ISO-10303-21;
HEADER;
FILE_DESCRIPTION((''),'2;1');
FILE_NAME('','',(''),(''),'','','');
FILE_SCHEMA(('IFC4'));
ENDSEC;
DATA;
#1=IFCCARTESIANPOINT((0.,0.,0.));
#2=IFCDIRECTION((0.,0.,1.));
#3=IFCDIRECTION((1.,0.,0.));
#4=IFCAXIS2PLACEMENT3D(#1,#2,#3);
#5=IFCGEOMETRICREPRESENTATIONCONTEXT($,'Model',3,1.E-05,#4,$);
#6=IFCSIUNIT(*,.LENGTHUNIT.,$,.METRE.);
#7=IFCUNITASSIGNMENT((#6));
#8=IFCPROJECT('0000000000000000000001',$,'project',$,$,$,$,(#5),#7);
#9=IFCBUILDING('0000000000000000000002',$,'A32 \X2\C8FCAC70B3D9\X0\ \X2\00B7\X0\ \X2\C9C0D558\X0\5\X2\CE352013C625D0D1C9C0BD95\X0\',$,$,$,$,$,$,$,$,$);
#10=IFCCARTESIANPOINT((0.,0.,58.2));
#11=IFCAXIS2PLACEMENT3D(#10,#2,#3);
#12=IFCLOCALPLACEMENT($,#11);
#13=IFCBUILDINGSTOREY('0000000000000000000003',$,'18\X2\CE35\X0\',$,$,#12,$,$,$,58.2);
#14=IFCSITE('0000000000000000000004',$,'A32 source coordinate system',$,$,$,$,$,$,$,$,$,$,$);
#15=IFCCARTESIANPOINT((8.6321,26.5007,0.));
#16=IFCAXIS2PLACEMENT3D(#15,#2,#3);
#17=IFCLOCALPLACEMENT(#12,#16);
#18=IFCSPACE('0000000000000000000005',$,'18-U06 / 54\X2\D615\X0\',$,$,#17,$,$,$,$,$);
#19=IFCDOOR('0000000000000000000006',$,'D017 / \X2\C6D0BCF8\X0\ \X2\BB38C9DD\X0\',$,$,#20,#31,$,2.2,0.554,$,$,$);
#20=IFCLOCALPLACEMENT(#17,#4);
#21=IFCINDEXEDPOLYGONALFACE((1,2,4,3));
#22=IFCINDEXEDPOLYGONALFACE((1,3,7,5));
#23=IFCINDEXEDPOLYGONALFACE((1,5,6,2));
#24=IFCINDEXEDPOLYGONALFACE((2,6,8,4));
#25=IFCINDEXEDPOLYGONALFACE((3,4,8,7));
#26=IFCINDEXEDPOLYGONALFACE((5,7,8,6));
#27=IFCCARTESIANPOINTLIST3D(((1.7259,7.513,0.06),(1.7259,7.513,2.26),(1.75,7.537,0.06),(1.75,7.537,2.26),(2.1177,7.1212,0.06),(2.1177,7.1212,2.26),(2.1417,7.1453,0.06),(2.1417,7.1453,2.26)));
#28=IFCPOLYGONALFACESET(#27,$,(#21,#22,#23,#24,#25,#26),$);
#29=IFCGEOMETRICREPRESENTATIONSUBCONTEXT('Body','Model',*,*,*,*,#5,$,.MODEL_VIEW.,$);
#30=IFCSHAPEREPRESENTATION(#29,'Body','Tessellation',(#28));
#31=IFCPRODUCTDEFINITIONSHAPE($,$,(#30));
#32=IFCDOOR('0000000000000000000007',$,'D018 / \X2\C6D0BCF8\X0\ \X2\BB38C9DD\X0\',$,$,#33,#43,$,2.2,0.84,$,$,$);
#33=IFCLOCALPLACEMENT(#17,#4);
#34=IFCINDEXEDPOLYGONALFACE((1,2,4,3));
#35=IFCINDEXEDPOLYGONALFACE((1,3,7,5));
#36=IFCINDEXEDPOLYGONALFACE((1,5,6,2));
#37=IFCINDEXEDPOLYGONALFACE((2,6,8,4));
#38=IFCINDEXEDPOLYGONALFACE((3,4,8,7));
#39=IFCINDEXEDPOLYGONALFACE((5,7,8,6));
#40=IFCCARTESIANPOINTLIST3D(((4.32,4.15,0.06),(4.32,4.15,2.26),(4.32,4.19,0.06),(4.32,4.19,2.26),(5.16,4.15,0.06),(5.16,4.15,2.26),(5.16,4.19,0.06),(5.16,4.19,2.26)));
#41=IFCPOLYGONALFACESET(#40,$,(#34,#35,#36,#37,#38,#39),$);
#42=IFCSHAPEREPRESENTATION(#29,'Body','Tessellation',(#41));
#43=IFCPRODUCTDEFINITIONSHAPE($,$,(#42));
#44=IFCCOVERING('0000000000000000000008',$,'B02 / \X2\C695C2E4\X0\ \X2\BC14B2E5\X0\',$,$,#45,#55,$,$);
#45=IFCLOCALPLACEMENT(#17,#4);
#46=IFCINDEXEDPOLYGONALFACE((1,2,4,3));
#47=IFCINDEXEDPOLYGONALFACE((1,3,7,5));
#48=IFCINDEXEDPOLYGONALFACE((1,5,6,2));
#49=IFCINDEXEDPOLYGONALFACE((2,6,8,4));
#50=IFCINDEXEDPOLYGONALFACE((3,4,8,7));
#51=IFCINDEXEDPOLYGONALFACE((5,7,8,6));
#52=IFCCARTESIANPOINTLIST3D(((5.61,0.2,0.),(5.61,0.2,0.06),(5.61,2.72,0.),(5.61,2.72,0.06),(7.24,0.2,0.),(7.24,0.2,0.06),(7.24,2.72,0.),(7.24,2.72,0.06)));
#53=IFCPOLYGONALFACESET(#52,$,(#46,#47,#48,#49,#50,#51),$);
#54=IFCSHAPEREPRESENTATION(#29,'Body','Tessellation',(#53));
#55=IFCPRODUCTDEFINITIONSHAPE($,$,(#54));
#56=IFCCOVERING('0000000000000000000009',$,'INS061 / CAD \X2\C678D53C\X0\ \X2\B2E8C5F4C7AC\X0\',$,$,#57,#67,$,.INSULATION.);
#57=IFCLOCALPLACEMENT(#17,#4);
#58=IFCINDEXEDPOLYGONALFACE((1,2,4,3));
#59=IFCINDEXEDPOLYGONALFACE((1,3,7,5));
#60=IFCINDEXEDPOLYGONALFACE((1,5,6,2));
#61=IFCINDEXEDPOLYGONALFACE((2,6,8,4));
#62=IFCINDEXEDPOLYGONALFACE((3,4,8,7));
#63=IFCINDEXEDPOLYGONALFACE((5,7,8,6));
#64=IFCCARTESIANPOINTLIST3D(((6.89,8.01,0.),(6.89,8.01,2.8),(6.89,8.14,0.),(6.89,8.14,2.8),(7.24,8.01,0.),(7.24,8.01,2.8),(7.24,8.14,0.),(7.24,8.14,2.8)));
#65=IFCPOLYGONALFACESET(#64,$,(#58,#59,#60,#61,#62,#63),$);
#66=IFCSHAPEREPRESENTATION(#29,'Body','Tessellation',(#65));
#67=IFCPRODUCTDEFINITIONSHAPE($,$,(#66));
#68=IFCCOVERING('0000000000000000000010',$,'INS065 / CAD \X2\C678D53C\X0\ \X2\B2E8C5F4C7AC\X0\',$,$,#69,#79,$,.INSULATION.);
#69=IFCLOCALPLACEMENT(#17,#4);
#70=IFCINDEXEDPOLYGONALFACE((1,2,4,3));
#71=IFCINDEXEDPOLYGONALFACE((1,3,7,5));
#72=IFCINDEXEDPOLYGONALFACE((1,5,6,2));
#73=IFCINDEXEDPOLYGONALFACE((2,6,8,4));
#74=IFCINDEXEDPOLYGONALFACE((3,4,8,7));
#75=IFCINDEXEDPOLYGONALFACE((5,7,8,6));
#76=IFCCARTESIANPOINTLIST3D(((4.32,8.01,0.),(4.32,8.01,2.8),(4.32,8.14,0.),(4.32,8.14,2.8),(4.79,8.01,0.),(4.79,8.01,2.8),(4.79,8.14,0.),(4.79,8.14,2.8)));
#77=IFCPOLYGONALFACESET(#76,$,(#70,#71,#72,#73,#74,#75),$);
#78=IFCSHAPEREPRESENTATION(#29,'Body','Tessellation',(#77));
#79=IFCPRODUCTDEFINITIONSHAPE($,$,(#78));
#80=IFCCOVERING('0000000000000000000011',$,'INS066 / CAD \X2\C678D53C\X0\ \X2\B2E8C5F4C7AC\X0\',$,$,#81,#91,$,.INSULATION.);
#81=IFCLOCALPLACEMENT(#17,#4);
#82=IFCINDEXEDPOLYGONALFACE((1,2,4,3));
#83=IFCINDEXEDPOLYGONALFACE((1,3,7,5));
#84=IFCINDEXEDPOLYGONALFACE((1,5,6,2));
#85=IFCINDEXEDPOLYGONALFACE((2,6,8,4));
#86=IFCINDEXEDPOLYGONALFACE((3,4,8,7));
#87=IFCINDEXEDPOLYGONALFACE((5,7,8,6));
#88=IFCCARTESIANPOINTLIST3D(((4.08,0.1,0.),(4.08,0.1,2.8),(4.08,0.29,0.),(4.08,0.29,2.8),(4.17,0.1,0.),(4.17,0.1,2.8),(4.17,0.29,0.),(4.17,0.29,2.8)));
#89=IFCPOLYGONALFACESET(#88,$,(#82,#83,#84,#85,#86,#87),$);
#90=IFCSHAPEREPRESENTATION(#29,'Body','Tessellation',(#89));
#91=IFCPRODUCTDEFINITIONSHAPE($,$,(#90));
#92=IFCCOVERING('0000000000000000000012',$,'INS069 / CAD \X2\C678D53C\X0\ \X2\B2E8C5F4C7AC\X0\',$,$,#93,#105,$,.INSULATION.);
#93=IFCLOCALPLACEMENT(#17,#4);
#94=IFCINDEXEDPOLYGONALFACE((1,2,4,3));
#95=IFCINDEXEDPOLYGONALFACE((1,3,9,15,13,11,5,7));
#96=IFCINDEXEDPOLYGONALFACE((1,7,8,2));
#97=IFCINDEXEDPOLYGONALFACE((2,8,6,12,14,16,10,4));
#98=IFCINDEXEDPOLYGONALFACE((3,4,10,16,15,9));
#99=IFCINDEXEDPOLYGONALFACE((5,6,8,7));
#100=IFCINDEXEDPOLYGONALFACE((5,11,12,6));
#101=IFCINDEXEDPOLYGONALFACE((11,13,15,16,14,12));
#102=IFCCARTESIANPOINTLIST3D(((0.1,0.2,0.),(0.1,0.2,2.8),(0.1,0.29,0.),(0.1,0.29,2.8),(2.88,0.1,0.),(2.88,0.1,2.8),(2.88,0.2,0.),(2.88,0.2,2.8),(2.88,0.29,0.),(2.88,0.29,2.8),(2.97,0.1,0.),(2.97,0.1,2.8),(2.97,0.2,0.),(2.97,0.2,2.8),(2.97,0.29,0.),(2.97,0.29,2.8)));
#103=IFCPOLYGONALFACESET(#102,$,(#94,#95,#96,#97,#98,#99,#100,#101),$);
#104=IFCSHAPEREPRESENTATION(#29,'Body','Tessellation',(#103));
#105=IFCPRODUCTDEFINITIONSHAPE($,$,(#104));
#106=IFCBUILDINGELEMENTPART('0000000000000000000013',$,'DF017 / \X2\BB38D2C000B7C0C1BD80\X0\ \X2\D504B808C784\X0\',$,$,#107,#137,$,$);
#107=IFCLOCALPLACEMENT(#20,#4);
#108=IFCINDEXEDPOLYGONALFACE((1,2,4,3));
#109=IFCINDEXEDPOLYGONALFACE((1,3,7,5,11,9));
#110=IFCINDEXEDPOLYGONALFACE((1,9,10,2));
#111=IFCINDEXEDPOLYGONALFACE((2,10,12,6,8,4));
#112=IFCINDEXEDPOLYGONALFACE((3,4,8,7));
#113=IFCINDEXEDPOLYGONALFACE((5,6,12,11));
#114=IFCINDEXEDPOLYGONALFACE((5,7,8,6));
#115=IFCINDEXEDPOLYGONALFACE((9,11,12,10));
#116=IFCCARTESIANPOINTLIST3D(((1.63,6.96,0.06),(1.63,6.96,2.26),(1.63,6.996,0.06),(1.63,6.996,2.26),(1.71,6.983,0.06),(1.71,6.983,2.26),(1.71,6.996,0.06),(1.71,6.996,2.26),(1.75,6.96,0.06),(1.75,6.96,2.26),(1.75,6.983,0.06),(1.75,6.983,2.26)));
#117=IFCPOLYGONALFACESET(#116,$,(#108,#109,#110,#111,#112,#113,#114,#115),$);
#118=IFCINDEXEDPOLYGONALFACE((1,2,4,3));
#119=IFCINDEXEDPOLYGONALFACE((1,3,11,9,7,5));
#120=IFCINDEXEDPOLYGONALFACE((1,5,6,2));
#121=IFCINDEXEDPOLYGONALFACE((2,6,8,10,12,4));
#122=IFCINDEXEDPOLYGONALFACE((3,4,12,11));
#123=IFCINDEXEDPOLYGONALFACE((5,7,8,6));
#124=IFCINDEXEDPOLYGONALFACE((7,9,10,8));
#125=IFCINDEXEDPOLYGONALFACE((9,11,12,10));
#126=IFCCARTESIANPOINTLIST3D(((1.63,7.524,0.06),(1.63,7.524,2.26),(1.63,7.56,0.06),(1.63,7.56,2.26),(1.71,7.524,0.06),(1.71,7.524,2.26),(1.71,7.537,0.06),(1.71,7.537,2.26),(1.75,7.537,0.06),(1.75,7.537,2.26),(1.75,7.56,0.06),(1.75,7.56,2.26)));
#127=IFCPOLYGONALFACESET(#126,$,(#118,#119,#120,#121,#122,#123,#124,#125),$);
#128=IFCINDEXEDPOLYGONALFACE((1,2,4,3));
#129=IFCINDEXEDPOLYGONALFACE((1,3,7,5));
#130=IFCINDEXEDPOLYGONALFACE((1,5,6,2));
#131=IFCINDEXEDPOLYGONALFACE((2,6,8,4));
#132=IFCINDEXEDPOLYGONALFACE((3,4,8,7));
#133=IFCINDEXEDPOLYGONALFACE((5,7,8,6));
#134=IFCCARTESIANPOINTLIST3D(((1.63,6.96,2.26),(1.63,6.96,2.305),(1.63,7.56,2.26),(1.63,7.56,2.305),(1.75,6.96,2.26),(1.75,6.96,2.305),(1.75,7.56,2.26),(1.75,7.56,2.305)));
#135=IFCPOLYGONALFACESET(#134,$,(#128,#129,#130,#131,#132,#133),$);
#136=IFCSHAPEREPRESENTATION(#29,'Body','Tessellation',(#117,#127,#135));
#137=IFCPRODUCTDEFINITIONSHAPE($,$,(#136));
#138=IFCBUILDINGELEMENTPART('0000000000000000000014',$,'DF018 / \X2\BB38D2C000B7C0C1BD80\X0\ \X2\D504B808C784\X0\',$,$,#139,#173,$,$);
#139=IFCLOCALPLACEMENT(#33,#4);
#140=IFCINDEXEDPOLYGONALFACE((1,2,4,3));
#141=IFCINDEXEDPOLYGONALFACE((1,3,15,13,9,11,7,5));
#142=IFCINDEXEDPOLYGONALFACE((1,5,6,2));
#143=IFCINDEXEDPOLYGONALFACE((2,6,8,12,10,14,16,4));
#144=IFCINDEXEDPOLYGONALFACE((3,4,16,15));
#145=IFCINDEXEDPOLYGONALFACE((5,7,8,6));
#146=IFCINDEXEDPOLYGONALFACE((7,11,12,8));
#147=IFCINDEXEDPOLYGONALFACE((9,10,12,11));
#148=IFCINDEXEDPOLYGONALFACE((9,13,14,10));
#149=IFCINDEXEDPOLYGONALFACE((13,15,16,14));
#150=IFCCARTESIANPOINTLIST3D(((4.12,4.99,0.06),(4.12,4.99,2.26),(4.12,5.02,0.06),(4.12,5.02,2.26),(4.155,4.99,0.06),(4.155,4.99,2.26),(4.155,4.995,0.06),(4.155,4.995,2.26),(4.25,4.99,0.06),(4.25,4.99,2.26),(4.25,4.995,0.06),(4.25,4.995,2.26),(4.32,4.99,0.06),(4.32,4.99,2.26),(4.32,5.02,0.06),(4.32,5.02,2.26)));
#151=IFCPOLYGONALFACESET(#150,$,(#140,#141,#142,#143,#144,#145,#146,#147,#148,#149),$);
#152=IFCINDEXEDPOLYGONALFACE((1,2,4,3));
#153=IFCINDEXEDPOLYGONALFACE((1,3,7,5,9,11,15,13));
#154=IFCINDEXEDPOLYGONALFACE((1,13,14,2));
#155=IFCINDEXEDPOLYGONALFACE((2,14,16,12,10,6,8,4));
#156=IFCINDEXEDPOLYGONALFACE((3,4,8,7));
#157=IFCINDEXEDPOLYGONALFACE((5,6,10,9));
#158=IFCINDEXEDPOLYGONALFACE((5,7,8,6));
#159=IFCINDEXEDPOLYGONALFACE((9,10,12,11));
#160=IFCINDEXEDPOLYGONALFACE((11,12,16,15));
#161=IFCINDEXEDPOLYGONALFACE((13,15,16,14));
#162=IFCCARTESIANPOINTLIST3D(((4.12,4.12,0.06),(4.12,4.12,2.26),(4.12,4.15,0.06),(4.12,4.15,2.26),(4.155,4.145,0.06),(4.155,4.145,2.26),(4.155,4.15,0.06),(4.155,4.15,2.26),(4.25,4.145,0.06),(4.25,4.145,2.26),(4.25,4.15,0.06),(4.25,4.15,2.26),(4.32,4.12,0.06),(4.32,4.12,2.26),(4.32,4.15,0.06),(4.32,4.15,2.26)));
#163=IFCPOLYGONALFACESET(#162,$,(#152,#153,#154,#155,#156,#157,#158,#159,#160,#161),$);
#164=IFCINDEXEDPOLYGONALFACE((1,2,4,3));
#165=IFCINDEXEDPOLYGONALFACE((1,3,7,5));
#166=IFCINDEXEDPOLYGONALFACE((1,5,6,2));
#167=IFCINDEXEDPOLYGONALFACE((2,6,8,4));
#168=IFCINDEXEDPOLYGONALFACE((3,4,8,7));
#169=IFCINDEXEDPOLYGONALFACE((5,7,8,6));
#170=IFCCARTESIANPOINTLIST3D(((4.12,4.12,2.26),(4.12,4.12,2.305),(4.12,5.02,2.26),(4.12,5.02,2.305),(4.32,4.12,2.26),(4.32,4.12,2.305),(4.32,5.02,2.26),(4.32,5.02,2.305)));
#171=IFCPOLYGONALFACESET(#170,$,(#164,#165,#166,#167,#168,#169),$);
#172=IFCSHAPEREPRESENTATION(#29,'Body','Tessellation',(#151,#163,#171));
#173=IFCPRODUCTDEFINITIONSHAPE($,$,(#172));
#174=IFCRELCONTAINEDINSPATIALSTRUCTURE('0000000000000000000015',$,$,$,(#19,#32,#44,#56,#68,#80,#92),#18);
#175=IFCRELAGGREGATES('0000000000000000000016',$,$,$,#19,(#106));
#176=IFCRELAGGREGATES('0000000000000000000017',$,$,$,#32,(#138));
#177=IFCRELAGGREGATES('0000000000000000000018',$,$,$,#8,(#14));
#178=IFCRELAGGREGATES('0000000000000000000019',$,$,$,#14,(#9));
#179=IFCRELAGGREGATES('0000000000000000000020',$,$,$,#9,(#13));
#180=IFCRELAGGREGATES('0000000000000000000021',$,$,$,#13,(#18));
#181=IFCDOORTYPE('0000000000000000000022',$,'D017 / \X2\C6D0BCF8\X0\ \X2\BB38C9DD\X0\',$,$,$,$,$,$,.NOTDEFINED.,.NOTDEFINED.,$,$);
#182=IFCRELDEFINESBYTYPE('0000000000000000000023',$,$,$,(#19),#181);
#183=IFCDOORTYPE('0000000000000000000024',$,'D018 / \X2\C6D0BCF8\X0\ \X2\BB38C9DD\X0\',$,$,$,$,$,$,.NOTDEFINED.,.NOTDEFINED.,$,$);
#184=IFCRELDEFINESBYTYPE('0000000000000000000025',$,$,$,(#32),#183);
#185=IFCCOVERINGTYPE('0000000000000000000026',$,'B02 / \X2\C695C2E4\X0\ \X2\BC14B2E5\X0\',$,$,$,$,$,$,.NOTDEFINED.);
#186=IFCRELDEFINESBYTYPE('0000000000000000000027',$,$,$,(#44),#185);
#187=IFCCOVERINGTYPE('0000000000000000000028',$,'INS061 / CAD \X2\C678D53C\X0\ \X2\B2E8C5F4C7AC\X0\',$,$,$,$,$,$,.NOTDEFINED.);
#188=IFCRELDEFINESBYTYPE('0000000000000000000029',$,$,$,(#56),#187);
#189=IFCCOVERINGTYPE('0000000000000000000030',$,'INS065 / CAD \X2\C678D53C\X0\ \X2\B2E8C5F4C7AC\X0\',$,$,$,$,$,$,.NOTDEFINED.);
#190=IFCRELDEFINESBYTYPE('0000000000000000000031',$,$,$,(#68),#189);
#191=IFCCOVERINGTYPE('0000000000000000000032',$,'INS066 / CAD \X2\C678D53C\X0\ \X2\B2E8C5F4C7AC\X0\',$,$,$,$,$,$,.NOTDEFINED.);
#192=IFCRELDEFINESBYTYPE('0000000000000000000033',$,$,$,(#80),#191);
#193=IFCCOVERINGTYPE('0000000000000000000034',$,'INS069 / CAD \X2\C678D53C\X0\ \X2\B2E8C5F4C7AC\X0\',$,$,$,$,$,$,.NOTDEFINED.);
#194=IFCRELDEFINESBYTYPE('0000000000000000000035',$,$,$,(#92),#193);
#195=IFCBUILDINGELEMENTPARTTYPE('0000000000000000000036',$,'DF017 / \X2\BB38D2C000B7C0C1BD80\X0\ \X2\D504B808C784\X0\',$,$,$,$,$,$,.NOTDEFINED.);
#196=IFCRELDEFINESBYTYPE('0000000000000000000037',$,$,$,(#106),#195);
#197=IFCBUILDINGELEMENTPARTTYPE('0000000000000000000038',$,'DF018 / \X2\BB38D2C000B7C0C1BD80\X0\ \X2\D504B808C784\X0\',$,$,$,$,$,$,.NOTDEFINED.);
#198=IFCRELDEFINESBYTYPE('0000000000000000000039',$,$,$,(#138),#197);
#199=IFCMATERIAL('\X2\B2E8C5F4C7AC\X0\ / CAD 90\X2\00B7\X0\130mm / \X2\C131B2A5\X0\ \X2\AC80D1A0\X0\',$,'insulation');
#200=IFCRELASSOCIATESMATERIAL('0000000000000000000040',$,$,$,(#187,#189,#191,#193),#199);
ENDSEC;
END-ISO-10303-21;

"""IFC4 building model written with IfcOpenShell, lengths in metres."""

from ifc_helpers import new_model, si_unit, frame, origin, origin_with_axes, place, context, subcontext, project, spatial, polyline, outline, extrude, source, transform, mapped, material, type_object, type_shapes, element, aggregate, save


model = new_model("IFC4")

# Units and contexts
model_context = context("Model", 3, precision=1e-05, world=origin_with_axes())
body_context = subcontext(model_context, "Body", "Model", "MODEL_VIEW")
ifc_project = project(units=[si_unit("LENGTHUNIT", "METRE")], contexts=[model_context])

# Site, building, storey, space
storey_placement = place(None, frame((0.0, 0.0, 58.2), z_axis=(0.0, 0.0, 1.0), x_axis=(1.0, 0.0, 0.0)))
space_1_placement = place(storey_placement, frame((8.6321, 26.5007, 0.0), z_axis=(0.0, 0.0, 1.0), x_axis=(1.0, 0.0, 0.0)))
site = spatial("IfcSite", under=ifc_project, Name="A32 source coordinate system")
building = spatial("IfcBuilding", under=site, Name="A32 주거동 · 지하5층–옥탑지붕")
storey = spatial("IfcBuildingStorey", under=building, at=storey_placement, Name="18층", Elevation=58.2)
space_1 = spatial("IfcSpace", under=storey, at=space_1_placement, Name="18-U06 / 54형")

# Doors
door_type_1 = type_object("IfcDoorType", Name="D017 / 원본 문짝", OperationType="NOTDEFINED", PredefinedType="NOTDEFINED")
shared_shape_1 = source(origin(), body_context, "Body", "SweptSolid", [
    extrude(outline(polyline([(1.75, 7.537), (2.1417, 7.1453), (2.1177, 7.1212), (1.7259, 7.513), (1.75, 7.537)])), frame((0.0, 0.0, 0.06)), (0.0, 0.0, 1.0), 2.2),
])
type_shapes(door_type_1, [shared_shape_1])
door_1_placement = place(space_1_placement, origin_with_axes())
door_1 = element("IfcDoor", 1, at=door_1_placement, inside=space_1, type_object=door_type_1, Name="D017 / 원본 문짝", OverallHeight=2.2, OverallWidth=0.554, context=body_context, shape_type="MappedRepresentation", body=[
    mapped(shared_shape_1, transform((0.0, 0.0, 0.0), scale=1.0)),
])
door_type_2 = type_object("IfcDoorType", Name="D018 / 원본 문짝", OperationType="NOTDEFINED", PredefinedType="NOTDEFINED")
shared_shape_2 = source(origin(), body_context, "Body", "SweptSolid", [
    extrude(outline(polyline([(5.16, 4.19), (5.16, 4.15), (4.32, 4.15), (4.32, 4.19), (5.16, 4.19)])), frame((0.0, 0.0, 0.06)), (0.0, 0.0, 1.0), 2.2),
])
type_shapes(door_type_2, [shared_shape_2])
door_2_placement = place(space_1_placement, origin_with_axes())
door_2 = element("IfcDoor", 2, at=door_2_placement, inside=space_1, type_object=door_type_2, Name="D018 / 원본 문짝", OverallHeight=2.2, OverallWidth=0.84, context=body_context, shape_type="MappedRepresentation", body=[
    mapped(shared_shape_2, transform((0.0, 0.0, 0.0), scale=1.0)),
])

# Coverings
covering_type_1 = type_object("IfcCoveringType", Name="B02 / 욕실 바닥", PredefinedType="NOTDEFINED")
shared_shape_3 = source(origin(), body_context, "Body", "SweptSolid", [
    extrude(outline(polyline([(5.61, 2.72), (7.24, 2.72), (7.24, 0.2), (5.61, 0.2), (5.61, 2.72)])), origin(), (0.0, 0.0, 1.0), 0.06),
])
type_shapes(covering_type_1, [shared_shape_3])
covering_1_placement = place(space_1_placement, origin_with_axes())
element("IfcCovering", 3, at=covering_1_placement, inside=space_1, type_object=covering_type_1, Name="B02 / 욕실 바닥", context=body_context, shape_type="MappedRepresentation", body=[
    mapped(shared_shape_3, transform((0.0, 0.0, 0.0), scale=1.0)),
])
ifc_material = material(Name="단열재 / CAD 90·130mm / 성능 검토", Category="insulation")
covering_type_2 = type_object("IfcCoveringType", Name="INS061 / CAD 외피 단열재", PredefinedType="NOTDEFINED", material=ifc_material)
shared_shape_4 = source(origin(), body_context, "Body", "SweptSolid", [
    extrude(outline(polyline([(6.89, 8.01), (6.89, 8.14), (7.24, 8.14), (7.24, 8.01), (6.89, 8.01)])), origin(), (0.0, 0.0, 1.0), 2.8),
])
type_shapes(covering_type_2, [shared_shape_4])
covering_2_placement = place(space_1_placement, origin_with_axes())
element("IfcCovering", 4, at=covering_2_placement, inside=space_1, type_object=covering_type_2, Name="INS061 / CAD 외피 단열재", PredefinedType="INSULATION", context=body_context, shape_type="MappedRepresentation", body=[
    mapped(shared_shape_4, transform((0.0, 0.0, 0.0), scale=1.0)),
])
covering_type_3 = type_object("IfcCoveringType", Name="INS065 / CAD 외피 단열재", PredefinedType="NOTDEFINED", material=ifc_material)
shared_shape_5 = source(origin(), body_context, "Body", "SweptSolid", [
    extrude(outline(polyline([(4.32, 8.01), (4.32, 8.14), (4.79, 8.14), (4.79, 8.01), (4.32, 8.01)])), origin(), (0.0, 0.0, 1.0), 2.8),
])
type_shapes(covering_type_3, [shared_shape_5])
covering_3_placement = place(space_1_placement, origin_with_axes())
element("IfcCovering", 5, at=covering_3_placement, inside=space_1, type_object=covering_type_3, Name="INS065 / CAD 외피 단열재", PredefinedType="INSULATION", context=body_context, shape_type="MappedRepresentation", body=[
    mapped(shared_shape_5, transform((0.0, 0.0, 0.0), scale=1.0)),
])
covering_type_4 = type_object("IfcCoveringType", Name="INS066 / CAD 외피 단열재", PredefinedType="NOTDEFINED", material=ifc_material)
shared_shape_6 = source(origin(), body_context, "Body", "SweptSolid", [
    extrude(outline(polyline([(4.08, 0.29), (4.17, 0.29), (4.17, 0.1), (4.08, 0.1), (4.08, 0.29)])), origin(), (0.0, 0.0, 1.0), 2.8),
])
type_shapes(covering_type_4, [shared_shape_6])
covering_4_placement = place(space_1_placement, origin_with_axes())
element("IfcCovering", 6, at=covering_4_placement, inside=space_1, type_object=covering_type_4, Name="INS066 / CAD 외피 단열재", PredefinedType="INSULATION", context=body_context, shape_type="MappedRepresentation", body=[
    mapped(shared_shape_6, transform((0.0, 0.0, 0.0), scale=1.0)),
])
covering_type_5 = type_object("IfcCoveringType", Name="INS069 / CAD 외피 단열재", PredefinedType="NOTDEFINED", material=ifc_material)
shared_shape_7 = source(origin(), body_context, "Body", "SweptSolid", [
    extrude(outline(polyline([(2.97, 0.1), (2.88, 0.1), (2.88, 0.2), (0.1, 0.2), (0.1, 0.29), (2.88, 0.29), (2.97, 0.29), (2.97, 0.2), (2.97, 0.1)])), origin(), (0.0, 0.0, 1.0), 2.8),
])
type_shapes(covering_type_5, [shared_shape_7])
covering_5_placement = place(space_1_placement, origin_with_axes())
element("IfcCovering", 7, at=covering_5_placement, inside=space_1, type_object=covering_type_5, Name="INS069 / CAD 외피 단열재", PredefinedType="INSULATION", context=body_context, shape_type="MappedRepresentation", body=[
    mapped(shared_shape_7, transform((0.0, 0.0, 0.0), scale=1.0)),
])

# Building element parts
building_element_part_type_1 = type_object("IfcBuildingElementPartType", Name="DF017 / 문틀·상부 프레임", PredefinedType="NOTDEFINED")
shared_shape_8 = source(origin(), body_context, "Body", "SweptSolid", [
    extrude(outline(polyline([(1.63, 6.996), (1.71, 6.996), (1.71, 6.983), (1.75, 6.983), (1.75, 6.96), (1.63, 6.96), (1.63, 6.996)])), frame((0.0, 0.0, 0.06)), (0.0, 0.0, 1.0), 2.2),
    extrude(outline(polyline([(1.75, 7.56), (1.75, 7.537), (1.71, 7.537), (1.71, 7.524), (1.63, 7.524), (1.63, 7.56), (1.75, 7.56)])), frame((0.0, 0.0, 0.06)), (0.0, 0.0, 1.0), 2.2),
    extrude(outline(polyline([(1.63, 6.96), (1.63, 7.56), (1.75, 7.56), (1.75, 6.96), (1.63, 6.96)])), frame((0.0, 0.0, 2.26)), (0.0, 0.0, 1.0), 0.045),
])
type_shapes(building_element_part_type_1, [shared_shape_8])
building_element_part_1_placement = place(door_1_placement, origin_with_axes())
building_element_part_1 = element("IfcBuildingElementPart", 8, at=building_element_part_1_placement, type_object=building_element_part_type_1, Name="DF017 / 문틀·상부 프레임", context=body_context, shape_type="MappedRepresentation", body=[
    mapped(shared_shape_8, transform((0.0, 0.0, 0.0), scale=1.0)),
])
aggregate(door_1, [building_element_part_1])
building_element_part_type_2 = type_object("IfcBuildingElementPartType", Name="DF018 / 문틀·상부 프레임", PredefinedType="NOTDEFINED")
shared_shape_9 = source(origin(), body_context, "Body", "SweptSolid", [
    extrude(outline(polyline([(4.32, 4.99), (4.25, 4.99), (4.25, 4.995), (4.155, 4.995), (4.155, 4.99), (4.12, 4.99), (4.12, 5.02), (4.32, 5.02), (4.32, 4.99)])), frame((0.0, 0.0, 0.06)), (0.0, 0.0, 1.0), 2.2),
    extrude(outline(polyline([(4.12, 4.12), (4.12, 4.15), (4.155, 4.15), (4.155, 4.145), (4.25, 4.145), (4.25, 4.15), (4.32, 4.15), (4.32, 4.12), (4.12, 4.12)])), frame((0.0, 0.0, 0.06)), (0.0, 0.0, 1.0), 2.2),
    extrude(outline(polyline([(4.12, 4.12), (4.12, 5.02), (4.32, 5.02), (4.32, 4.12), (4.12, 4.12)])), frame((0.0, 0.0, 2.26)), (0.0, 0.0, 1.0), 0.045),
])
type_shapes(building_element_part_type_2, [shared_shape_9])
building_element_part_2_placement = place(door_2_placement, origin_with_axes())
building_element_part_2 = element("IfcBuildingElementPart", 9, at=building_element_part_2_placement, type_object=building_element_part_type_2, Name="DF018 / 문틀·상부 프레임", context=body_context, shape_type="MappedRepresentation", body=[
    mapped(shared_shape_9, transform((0.0, 0.0, 0.0), scale=1.0)),
])
aggregate(door_2, [building_element_part_2])

save(model, "model.ifc")
